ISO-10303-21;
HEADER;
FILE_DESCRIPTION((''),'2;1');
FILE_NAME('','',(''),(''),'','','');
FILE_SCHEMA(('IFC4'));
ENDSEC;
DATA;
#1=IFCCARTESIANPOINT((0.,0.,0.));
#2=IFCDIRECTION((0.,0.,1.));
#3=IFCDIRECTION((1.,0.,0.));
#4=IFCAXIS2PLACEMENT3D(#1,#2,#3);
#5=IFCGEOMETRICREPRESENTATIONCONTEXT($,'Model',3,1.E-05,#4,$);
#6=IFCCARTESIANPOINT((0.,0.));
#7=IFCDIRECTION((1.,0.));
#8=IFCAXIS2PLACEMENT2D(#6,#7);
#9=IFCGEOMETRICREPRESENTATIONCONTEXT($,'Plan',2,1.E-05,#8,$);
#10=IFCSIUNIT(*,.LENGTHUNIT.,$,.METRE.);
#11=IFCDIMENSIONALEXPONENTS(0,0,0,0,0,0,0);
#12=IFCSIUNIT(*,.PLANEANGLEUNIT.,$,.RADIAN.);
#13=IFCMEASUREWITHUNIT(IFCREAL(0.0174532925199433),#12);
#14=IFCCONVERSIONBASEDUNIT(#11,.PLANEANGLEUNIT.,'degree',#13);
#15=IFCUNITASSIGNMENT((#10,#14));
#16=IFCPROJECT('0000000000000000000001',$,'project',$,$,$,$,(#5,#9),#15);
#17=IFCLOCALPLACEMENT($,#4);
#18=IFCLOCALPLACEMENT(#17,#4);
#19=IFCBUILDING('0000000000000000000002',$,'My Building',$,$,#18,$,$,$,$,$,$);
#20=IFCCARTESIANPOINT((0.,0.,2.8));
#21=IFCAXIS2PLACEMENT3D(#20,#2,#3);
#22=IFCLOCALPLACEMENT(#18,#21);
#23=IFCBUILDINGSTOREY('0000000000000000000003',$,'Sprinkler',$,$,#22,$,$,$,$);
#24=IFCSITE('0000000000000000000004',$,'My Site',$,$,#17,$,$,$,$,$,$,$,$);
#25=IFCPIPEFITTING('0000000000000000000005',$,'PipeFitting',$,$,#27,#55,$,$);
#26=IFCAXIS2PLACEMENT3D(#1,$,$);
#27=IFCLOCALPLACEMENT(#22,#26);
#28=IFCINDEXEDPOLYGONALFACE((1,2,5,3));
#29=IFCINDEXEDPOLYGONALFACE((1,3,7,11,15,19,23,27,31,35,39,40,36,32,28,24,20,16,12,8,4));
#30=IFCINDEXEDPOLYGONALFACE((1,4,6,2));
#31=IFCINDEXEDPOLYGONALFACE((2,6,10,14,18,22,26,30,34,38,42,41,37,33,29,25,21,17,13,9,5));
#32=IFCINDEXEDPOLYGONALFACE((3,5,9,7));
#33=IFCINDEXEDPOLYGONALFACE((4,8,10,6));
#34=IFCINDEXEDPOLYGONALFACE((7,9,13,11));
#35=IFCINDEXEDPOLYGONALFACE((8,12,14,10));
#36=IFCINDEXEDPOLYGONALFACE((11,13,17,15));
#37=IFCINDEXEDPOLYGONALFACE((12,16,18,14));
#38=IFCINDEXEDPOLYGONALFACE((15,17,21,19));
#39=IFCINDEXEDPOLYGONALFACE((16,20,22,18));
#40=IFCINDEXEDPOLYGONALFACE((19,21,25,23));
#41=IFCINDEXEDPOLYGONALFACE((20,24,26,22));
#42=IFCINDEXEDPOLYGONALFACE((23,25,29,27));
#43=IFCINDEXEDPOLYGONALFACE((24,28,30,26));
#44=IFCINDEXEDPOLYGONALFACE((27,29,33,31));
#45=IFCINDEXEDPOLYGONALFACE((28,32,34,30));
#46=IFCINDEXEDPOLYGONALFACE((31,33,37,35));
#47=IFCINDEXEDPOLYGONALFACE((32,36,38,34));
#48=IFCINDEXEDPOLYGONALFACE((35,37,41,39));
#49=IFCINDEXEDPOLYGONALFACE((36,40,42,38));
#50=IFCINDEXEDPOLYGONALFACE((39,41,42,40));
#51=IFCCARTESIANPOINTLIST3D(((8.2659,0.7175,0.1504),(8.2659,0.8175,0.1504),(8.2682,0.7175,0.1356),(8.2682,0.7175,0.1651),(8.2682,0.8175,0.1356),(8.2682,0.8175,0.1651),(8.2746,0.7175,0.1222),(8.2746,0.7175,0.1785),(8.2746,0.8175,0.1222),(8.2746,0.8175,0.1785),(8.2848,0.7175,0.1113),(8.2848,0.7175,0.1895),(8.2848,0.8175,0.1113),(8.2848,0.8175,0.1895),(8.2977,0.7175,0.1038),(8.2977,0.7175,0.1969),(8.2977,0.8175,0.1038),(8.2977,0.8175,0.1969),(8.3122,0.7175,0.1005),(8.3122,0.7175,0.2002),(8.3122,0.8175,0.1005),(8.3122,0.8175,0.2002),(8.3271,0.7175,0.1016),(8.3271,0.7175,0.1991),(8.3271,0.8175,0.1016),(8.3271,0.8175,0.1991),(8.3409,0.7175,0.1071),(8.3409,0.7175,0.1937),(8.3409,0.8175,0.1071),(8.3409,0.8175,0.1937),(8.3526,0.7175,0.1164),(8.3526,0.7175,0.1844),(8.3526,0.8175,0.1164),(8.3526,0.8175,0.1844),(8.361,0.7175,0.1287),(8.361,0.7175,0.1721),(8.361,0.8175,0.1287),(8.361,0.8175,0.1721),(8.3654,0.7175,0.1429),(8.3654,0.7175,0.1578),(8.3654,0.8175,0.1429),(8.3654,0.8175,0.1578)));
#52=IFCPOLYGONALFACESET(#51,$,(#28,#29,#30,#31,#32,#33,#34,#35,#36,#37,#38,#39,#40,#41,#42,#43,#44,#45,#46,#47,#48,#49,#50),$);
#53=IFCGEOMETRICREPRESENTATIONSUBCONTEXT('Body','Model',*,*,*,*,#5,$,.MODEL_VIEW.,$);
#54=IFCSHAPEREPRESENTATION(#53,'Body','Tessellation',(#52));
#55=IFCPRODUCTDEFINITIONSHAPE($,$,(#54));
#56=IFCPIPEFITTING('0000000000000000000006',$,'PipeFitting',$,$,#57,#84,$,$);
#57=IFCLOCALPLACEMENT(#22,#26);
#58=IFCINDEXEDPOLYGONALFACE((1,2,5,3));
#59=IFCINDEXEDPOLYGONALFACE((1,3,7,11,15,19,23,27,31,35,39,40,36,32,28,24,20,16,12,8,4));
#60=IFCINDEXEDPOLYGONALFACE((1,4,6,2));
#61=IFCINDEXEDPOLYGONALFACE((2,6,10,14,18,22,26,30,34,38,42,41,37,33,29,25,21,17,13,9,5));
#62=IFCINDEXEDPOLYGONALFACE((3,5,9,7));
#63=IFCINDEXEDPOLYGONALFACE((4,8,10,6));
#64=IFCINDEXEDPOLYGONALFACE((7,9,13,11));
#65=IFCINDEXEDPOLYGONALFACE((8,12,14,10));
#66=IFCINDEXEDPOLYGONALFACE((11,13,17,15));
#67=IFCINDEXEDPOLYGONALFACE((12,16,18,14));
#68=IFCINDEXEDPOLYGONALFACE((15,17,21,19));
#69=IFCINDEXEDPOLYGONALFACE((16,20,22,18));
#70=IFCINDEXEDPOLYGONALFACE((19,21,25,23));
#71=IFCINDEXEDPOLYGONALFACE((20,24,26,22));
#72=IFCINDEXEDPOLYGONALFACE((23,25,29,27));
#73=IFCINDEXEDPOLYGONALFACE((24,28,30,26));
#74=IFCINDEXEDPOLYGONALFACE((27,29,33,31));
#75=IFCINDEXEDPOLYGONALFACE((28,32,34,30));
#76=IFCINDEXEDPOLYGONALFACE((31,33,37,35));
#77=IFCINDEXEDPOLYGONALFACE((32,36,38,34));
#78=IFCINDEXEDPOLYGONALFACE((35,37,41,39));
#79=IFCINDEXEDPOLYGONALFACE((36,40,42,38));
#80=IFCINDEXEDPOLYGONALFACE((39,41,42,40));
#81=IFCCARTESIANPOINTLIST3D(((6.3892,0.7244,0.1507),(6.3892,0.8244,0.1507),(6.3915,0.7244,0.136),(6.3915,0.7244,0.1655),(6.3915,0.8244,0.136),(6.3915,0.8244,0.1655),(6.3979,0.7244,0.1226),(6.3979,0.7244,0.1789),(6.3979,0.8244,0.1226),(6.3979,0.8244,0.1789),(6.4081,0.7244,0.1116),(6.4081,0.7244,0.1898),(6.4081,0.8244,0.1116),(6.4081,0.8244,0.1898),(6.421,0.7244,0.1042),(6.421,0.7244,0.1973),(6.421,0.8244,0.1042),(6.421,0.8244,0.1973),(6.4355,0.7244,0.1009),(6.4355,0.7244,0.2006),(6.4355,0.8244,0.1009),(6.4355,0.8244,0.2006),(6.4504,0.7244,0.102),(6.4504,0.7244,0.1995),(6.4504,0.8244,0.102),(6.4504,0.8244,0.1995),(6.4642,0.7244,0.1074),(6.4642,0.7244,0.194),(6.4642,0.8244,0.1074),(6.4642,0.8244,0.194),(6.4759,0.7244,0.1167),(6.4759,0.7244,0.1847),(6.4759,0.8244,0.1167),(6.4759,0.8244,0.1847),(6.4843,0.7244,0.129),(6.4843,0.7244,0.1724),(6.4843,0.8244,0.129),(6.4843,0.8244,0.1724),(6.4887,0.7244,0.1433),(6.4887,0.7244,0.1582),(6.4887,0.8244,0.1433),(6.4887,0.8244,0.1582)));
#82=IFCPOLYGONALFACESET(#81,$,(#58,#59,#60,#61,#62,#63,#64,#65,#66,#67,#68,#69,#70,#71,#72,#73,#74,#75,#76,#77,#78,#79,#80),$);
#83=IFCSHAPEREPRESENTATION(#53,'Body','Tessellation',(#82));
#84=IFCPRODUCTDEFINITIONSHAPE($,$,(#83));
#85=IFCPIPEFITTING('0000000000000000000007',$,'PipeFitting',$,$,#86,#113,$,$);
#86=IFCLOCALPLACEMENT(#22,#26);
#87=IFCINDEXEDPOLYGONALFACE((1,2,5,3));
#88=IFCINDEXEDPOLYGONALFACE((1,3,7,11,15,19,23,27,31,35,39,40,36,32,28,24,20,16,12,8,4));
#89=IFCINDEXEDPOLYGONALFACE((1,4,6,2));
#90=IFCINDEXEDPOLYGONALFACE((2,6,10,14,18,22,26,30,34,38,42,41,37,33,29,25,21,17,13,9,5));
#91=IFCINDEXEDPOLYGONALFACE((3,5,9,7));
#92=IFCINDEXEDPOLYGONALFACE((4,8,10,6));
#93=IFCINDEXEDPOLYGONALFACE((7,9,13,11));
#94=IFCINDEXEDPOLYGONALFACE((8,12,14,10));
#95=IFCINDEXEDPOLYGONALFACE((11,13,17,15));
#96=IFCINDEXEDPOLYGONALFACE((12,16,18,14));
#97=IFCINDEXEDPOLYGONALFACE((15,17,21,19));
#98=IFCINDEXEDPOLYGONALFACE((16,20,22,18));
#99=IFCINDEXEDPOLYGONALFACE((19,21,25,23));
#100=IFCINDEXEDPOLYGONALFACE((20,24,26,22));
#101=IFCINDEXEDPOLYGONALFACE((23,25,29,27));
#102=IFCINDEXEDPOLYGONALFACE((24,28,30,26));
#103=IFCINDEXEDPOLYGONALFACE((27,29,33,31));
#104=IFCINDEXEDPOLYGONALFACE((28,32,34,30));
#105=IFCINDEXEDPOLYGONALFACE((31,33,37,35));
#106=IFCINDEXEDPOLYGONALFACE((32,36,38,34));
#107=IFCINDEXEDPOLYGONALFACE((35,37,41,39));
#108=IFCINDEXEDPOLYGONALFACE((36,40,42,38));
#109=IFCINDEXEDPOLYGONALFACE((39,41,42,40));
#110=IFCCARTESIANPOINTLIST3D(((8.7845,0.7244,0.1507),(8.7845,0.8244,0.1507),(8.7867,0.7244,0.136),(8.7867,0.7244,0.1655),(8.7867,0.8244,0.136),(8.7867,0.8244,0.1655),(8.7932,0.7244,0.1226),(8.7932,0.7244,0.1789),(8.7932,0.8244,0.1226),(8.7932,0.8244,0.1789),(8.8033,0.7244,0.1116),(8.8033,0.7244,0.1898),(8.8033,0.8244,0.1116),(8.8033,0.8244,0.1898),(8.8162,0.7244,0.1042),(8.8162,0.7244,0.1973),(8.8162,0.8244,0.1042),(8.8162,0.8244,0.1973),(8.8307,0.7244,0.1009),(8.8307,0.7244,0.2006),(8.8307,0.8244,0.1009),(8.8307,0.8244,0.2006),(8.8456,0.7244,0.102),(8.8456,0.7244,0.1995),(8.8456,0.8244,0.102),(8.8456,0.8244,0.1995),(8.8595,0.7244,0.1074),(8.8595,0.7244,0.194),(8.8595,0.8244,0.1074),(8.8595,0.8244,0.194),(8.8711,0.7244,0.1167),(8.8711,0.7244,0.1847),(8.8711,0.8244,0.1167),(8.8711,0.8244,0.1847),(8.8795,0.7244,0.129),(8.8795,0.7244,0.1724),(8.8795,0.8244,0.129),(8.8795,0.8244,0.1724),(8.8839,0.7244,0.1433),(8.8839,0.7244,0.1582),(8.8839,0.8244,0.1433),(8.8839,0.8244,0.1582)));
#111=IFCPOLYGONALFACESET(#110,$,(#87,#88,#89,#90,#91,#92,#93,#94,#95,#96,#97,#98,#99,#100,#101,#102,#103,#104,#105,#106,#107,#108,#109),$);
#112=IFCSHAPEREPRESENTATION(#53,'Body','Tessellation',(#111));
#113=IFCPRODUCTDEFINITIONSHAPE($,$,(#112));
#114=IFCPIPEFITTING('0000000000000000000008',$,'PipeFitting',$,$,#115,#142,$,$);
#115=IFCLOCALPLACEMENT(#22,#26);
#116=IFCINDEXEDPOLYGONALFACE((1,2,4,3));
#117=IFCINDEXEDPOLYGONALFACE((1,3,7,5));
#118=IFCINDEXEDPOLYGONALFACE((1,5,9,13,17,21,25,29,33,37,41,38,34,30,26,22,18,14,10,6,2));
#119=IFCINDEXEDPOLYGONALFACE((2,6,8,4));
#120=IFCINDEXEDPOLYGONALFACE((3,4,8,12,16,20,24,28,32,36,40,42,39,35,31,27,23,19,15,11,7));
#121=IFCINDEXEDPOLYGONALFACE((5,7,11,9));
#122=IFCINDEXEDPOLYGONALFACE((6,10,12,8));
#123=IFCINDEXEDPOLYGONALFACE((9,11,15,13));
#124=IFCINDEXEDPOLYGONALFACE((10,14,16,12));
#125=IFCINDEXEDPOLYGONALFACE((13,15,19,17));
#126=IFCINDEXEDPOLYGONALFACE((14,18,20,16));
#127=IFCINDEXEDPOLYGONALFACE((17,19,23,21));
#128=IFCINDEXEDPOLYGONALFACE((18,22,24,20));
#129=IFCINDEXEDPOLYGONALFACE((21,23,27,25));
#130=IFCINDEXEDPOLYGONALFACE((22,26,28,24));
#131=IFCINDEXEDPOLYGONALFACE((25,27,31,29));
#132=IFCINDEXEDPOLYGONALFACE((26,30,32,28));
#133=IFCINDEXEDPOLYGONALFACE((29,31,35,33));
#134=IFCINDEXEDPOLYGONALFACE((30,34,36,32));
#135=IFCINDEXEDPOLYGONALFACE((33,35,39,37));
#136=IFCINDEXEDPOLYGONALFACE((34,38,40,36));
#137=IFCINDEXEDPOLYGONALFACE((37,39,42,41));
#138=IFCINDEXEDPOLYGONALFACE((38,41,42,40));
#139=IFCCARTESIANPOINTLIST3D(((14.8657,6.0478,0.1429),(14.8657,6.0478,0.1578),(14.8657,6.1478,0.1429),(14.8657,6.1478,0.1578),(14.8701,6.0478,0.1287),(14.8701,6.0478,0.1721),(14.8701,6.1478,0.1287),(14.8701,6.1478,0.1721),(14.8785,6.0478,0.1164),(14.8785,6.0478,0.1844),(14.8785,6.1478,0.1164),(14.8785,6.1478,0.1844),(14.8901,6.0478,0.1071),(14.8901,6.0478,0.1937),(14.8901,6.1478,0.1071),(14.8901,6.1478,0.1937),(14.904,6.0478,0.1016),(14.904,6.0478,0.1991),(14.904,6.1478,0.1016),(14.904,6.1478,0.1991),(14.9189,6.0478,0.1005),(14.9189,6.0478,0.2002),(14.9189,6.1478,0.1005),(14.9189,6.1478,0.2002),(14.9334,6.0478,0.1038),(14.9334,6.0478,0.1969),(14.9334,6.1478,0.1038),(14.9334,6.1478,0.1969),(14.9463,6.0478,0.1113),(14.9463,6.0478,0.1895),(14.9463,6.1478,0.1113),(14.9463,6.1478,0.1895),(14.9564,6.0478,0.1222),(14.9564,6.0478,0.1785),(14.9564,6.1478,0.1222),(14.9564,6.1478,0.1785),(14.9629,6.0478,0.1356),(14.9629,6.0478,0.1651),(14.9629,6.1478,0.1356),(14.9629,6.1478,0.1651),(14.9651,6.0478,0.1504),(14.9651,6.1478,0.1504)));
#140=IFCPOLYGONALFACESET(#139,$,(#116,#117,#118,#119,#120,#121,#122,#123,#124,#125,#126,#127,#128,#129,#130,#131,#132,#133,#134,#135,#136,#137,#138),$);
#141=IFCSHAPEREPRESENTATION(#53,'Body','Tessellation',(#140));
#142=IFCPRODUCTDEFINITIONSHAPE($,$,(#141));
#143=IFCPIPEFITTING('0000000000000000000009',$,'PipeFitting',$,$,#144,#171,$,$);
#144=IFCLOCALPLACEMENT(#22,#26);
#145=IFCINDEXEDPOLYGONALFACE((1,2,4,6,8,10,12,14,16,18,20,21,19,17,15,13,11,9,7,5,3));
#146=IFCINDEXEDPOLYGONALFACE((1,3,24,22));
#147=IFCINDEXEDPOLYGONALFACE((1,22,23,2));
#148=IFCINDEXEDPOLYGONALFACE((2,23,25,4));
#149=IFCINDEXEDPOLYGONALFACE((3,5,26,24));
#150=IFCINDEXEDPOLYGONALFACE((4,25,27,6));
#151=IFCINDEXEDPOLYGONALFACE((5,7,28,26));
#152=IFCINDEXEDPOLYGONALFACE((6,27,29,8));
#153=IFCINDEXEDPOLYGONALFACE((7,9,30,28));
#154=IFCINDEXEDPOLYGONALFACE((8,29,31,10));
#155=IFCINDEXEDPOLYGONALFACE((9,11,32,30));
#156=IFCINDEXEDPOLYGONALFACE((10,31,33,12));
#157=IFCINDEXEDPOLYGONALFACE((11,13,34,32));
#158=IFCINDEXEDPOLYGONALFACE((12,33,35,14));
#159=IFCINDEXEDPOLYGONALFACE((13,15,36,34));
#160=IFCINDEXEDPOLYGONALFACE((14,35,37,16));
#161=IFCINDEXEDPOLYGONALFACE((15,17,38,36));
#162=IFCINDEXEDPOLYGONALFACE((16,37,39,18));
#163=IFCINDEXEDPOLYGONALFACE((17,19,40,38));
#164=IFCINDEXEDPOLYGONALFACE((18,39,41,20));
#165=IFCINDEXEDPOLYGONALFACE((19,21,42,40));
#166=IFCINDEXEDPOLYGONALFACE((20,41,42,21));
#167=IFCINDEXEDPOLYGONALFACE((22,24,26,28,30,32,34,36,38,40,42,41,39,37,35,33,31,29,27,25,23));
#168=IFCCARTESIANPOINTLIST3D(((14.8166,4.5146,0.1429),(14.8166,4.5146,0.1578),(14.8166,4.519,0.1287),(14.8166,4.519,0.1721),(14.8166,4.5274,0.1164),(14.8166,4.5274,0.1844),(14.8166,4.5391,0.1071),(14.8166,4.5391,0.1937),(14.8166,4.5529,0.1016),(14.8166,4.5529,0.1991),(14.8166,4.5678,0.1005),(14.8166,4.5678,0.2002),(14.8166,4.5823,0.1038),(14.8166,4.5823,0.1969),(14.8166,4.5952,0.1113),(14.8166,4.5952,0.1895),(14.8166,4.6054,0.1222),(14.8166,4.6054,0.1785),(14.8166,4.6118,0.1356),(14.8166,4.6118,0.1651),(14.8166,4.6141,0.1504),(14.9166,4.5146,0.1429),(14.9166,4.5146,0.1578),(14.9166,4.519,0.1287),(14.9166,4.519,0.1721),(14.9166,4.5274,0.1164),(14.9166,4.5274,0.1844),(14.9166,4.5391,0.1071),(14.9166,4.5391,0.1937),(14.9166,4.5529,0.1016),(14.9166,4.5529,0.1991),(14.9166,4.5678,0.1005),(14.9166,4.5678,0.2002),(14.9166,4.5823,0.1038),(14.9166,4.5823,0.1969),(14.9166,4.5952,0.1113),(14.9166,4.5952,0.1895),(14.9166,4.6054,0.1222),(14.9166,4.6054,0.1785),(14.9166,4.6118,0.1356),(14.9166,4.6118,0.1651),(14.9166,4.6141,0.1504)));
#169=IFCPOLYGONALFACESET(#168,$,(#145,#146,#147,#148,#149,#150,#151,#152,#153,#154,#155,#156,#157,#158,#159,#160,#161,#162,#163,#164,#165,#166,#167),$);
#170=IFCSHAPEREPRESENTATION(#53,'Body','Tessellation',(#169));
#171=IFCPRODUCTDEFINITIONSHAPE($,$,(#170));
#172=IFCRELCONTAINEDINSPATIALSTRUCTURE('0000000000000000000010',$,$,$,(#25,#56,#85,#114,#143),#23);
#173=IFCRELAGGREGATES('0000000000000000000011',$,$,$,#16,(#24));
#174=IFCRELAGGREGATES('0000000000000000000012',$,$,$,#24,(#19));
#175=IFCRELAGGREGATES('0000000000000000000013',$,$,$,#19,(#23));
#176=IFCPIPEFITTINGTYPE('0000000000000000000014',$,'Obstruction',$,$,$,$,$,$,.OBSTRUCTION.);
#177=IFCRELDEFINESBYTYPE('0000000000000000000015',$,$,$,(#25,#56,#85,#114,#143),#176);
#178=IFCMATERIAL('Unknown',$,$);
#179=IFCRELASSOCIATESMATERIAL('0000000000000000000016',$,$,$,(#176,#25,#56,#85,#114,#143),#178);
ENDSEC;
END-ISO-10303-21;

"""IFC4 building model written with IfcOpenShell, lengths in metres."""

from ifc_helpers import new_model, entity, si_unit, converted_unit, frame, origin_with_axes, origin_2d_with_axis, place, context, subcontext, project, spatial, circle, extrude, material, material_profile, profile_set, profile_usage, type_object, element, save


model = new_model("IFC4")

# Units and contexts
model_context = context("Model", 3, precision=1e-05, world=origin_with_axes())
plan_context = context("Plan", 2, precision=1e-05, world=origin_2d_with_axis())
body_context = subcontext(model_context, "Body", "Model", "MODEL_VIEW")
ifc_project = project(units=[si_unit("LENGTHUNIT", "METRE"), converted_unit("PLANEANGLEUNIT", "degree", entity("IfcReal", 0.0174532925199433), si_unit("PLANEANGLEUNIT", "RADIAN"), dimensions=[0, 0, 0, 0, 0, 0, 0])], contexts=[model_context, plan_context])

# Site, building, storey
site_placement = place(None, origin_with_axes())
site = spatial("IfcSite", under=ifc_project, at=site_placement, Name="My Site")
building_placement = place(site_placement, origin_with_axes())
building = spatial("IfcBuilding", under=site, at=building_placement, Name="My Building")
storey_placement = place(building_placement, frame((0.0, 0.0, 2.8), z_axis=(0.0, 0.0, 1.0), x_axis=(1.0, 0.0, 0.0)))
storey = spatial("IfcBuildingStorey", under=building, at=storey_placement, Name="Sprinkler")

# Shared definitions
ifc_material = material(Name="Unknown")

# Pipe fittings
ifc_material_profile_1 = material_profile(ifc_material, circle(Radius=0.05))
ifc_profile_set_1 = profile_set([ifc_material_profile_1])
pipe_fitting_type_1 = type_object("IfcPipeFittingType", Name="Obstruction", PredefinedType="OBSTRUCTION", material=ifc_profile_set_1)
ifc_profile_usage_1 = profile_usage(ifc_profile_set_1, cardinal=5)
pipe_fitting_1_placement = place(storey_placement, frame((8.3159, 0.7175, 0.1504), z_axis=(0.0, 1.0, 0.0), x_axis=(-1.0, 0.0, 0.0)))
element("IfcPipeFitting", 1, at=pipe_fitting_1_placement, inside=storey, type_object=pipe_fitting_type_1, material=ifc_profile_usage_1, Name="PipeFitting", context=body_context, shape_type="SweptSolid", body=[
    extrude(circle(Radius=0.05), origin_with_axes(), (0.0, 0.0, 1.0), 0.1),
])
ifc_profile_usage_2 = profile_usage(ifc_profile_set_1, cardinal=5)
pipe_fitting_2_placement = place(storey_placement, frame((6.4392, 0.7244, 0.1507), z_axis=(0.0, 1.0, 0.000005), x_axis=(-1.0, 0.0, 0.0)))
element("IfcPipeFitting", 2, at=pipe_fitting_2_placement, inside=storey, type_object=pipe_fitting_type_1, material=ifc_profile_usage_2, Name="PipeFitting", context=body_context, shape_type="SweptSolid", body=[
    extrude(circle(Radius=0.05), origin_with_axes(), (0.0, 0.0, 1.0), 0.1),
])
ifc_profile_usage_3 = profile_usage(ifc_profile_set_1, cardinal=5)
pipe_fitting_3_placement = place(storey_placement, frame((8.8345, 0.7244, 0.1507), z_axis=(0.0, 1.0, 0.000005), x_axis=(-1.0, 0.0, 0.0)))
element("IfcPipeFitting", 3, at=pipe_fitting_3_placement, inside=storey, type_object=pipe_fitting_type_1, material=ifc_profile_usage_3, Name="PipeFitting", context=body_context, shape_type="SweptSolid", body=[
    extrude(circle(Radius=0.05), origin_with_axes(), (0.0, 0.0, 1.0), 0.1),
])
ifc_profile_usage_4 = profile_usage(ifc_profile_set_1, cardinal=5)
pipe_fitting_4_placement = place(storey_placement, frame((14.9151, 6.1478, 0.1504), z_axis=(0.0, -1.0, 0.0), x_axis=(1.0, 0.0, 0.0)))
element("IfcPipeFitting", 4, at=pipe_fitting_4_placement, inside=storey, type_object=pipe_fitting_type_1, material=ifc_profile_usage_4, Name="PipeFitting", context=body_context, shape_type="SweptSolid", body=[
    extrude(circle(Radius=0.05), origin_with_axes(), (0.0, 0.0, 1.0), 0.1),
])
ifc_profile_usage_5 = profile_usage(ifc_profile_set_1, cardinal=5)
pipe_fitting_5_placement = place(storey_placement, frame((14.8166, 4.5641, 0.1504), z_axis=(1.0, 0.0, 0.0), x_axis=(0.0, 1.0, 0.0)))
element("IfcPipeFitting", 5, at=pipe_fitting_5_placement, inside=storey, type_object=pipe_fitting_type_1, material=ifc_profile_usage_5, Name="PipeFitting", context=body_context, shape_type="SweptSolid", body=[
    extrude(circle(Radius=0.05), origin_with_axes(), (0.0, 0.0, 1.0), 0.1),
])

save(model, "model.ifc")
